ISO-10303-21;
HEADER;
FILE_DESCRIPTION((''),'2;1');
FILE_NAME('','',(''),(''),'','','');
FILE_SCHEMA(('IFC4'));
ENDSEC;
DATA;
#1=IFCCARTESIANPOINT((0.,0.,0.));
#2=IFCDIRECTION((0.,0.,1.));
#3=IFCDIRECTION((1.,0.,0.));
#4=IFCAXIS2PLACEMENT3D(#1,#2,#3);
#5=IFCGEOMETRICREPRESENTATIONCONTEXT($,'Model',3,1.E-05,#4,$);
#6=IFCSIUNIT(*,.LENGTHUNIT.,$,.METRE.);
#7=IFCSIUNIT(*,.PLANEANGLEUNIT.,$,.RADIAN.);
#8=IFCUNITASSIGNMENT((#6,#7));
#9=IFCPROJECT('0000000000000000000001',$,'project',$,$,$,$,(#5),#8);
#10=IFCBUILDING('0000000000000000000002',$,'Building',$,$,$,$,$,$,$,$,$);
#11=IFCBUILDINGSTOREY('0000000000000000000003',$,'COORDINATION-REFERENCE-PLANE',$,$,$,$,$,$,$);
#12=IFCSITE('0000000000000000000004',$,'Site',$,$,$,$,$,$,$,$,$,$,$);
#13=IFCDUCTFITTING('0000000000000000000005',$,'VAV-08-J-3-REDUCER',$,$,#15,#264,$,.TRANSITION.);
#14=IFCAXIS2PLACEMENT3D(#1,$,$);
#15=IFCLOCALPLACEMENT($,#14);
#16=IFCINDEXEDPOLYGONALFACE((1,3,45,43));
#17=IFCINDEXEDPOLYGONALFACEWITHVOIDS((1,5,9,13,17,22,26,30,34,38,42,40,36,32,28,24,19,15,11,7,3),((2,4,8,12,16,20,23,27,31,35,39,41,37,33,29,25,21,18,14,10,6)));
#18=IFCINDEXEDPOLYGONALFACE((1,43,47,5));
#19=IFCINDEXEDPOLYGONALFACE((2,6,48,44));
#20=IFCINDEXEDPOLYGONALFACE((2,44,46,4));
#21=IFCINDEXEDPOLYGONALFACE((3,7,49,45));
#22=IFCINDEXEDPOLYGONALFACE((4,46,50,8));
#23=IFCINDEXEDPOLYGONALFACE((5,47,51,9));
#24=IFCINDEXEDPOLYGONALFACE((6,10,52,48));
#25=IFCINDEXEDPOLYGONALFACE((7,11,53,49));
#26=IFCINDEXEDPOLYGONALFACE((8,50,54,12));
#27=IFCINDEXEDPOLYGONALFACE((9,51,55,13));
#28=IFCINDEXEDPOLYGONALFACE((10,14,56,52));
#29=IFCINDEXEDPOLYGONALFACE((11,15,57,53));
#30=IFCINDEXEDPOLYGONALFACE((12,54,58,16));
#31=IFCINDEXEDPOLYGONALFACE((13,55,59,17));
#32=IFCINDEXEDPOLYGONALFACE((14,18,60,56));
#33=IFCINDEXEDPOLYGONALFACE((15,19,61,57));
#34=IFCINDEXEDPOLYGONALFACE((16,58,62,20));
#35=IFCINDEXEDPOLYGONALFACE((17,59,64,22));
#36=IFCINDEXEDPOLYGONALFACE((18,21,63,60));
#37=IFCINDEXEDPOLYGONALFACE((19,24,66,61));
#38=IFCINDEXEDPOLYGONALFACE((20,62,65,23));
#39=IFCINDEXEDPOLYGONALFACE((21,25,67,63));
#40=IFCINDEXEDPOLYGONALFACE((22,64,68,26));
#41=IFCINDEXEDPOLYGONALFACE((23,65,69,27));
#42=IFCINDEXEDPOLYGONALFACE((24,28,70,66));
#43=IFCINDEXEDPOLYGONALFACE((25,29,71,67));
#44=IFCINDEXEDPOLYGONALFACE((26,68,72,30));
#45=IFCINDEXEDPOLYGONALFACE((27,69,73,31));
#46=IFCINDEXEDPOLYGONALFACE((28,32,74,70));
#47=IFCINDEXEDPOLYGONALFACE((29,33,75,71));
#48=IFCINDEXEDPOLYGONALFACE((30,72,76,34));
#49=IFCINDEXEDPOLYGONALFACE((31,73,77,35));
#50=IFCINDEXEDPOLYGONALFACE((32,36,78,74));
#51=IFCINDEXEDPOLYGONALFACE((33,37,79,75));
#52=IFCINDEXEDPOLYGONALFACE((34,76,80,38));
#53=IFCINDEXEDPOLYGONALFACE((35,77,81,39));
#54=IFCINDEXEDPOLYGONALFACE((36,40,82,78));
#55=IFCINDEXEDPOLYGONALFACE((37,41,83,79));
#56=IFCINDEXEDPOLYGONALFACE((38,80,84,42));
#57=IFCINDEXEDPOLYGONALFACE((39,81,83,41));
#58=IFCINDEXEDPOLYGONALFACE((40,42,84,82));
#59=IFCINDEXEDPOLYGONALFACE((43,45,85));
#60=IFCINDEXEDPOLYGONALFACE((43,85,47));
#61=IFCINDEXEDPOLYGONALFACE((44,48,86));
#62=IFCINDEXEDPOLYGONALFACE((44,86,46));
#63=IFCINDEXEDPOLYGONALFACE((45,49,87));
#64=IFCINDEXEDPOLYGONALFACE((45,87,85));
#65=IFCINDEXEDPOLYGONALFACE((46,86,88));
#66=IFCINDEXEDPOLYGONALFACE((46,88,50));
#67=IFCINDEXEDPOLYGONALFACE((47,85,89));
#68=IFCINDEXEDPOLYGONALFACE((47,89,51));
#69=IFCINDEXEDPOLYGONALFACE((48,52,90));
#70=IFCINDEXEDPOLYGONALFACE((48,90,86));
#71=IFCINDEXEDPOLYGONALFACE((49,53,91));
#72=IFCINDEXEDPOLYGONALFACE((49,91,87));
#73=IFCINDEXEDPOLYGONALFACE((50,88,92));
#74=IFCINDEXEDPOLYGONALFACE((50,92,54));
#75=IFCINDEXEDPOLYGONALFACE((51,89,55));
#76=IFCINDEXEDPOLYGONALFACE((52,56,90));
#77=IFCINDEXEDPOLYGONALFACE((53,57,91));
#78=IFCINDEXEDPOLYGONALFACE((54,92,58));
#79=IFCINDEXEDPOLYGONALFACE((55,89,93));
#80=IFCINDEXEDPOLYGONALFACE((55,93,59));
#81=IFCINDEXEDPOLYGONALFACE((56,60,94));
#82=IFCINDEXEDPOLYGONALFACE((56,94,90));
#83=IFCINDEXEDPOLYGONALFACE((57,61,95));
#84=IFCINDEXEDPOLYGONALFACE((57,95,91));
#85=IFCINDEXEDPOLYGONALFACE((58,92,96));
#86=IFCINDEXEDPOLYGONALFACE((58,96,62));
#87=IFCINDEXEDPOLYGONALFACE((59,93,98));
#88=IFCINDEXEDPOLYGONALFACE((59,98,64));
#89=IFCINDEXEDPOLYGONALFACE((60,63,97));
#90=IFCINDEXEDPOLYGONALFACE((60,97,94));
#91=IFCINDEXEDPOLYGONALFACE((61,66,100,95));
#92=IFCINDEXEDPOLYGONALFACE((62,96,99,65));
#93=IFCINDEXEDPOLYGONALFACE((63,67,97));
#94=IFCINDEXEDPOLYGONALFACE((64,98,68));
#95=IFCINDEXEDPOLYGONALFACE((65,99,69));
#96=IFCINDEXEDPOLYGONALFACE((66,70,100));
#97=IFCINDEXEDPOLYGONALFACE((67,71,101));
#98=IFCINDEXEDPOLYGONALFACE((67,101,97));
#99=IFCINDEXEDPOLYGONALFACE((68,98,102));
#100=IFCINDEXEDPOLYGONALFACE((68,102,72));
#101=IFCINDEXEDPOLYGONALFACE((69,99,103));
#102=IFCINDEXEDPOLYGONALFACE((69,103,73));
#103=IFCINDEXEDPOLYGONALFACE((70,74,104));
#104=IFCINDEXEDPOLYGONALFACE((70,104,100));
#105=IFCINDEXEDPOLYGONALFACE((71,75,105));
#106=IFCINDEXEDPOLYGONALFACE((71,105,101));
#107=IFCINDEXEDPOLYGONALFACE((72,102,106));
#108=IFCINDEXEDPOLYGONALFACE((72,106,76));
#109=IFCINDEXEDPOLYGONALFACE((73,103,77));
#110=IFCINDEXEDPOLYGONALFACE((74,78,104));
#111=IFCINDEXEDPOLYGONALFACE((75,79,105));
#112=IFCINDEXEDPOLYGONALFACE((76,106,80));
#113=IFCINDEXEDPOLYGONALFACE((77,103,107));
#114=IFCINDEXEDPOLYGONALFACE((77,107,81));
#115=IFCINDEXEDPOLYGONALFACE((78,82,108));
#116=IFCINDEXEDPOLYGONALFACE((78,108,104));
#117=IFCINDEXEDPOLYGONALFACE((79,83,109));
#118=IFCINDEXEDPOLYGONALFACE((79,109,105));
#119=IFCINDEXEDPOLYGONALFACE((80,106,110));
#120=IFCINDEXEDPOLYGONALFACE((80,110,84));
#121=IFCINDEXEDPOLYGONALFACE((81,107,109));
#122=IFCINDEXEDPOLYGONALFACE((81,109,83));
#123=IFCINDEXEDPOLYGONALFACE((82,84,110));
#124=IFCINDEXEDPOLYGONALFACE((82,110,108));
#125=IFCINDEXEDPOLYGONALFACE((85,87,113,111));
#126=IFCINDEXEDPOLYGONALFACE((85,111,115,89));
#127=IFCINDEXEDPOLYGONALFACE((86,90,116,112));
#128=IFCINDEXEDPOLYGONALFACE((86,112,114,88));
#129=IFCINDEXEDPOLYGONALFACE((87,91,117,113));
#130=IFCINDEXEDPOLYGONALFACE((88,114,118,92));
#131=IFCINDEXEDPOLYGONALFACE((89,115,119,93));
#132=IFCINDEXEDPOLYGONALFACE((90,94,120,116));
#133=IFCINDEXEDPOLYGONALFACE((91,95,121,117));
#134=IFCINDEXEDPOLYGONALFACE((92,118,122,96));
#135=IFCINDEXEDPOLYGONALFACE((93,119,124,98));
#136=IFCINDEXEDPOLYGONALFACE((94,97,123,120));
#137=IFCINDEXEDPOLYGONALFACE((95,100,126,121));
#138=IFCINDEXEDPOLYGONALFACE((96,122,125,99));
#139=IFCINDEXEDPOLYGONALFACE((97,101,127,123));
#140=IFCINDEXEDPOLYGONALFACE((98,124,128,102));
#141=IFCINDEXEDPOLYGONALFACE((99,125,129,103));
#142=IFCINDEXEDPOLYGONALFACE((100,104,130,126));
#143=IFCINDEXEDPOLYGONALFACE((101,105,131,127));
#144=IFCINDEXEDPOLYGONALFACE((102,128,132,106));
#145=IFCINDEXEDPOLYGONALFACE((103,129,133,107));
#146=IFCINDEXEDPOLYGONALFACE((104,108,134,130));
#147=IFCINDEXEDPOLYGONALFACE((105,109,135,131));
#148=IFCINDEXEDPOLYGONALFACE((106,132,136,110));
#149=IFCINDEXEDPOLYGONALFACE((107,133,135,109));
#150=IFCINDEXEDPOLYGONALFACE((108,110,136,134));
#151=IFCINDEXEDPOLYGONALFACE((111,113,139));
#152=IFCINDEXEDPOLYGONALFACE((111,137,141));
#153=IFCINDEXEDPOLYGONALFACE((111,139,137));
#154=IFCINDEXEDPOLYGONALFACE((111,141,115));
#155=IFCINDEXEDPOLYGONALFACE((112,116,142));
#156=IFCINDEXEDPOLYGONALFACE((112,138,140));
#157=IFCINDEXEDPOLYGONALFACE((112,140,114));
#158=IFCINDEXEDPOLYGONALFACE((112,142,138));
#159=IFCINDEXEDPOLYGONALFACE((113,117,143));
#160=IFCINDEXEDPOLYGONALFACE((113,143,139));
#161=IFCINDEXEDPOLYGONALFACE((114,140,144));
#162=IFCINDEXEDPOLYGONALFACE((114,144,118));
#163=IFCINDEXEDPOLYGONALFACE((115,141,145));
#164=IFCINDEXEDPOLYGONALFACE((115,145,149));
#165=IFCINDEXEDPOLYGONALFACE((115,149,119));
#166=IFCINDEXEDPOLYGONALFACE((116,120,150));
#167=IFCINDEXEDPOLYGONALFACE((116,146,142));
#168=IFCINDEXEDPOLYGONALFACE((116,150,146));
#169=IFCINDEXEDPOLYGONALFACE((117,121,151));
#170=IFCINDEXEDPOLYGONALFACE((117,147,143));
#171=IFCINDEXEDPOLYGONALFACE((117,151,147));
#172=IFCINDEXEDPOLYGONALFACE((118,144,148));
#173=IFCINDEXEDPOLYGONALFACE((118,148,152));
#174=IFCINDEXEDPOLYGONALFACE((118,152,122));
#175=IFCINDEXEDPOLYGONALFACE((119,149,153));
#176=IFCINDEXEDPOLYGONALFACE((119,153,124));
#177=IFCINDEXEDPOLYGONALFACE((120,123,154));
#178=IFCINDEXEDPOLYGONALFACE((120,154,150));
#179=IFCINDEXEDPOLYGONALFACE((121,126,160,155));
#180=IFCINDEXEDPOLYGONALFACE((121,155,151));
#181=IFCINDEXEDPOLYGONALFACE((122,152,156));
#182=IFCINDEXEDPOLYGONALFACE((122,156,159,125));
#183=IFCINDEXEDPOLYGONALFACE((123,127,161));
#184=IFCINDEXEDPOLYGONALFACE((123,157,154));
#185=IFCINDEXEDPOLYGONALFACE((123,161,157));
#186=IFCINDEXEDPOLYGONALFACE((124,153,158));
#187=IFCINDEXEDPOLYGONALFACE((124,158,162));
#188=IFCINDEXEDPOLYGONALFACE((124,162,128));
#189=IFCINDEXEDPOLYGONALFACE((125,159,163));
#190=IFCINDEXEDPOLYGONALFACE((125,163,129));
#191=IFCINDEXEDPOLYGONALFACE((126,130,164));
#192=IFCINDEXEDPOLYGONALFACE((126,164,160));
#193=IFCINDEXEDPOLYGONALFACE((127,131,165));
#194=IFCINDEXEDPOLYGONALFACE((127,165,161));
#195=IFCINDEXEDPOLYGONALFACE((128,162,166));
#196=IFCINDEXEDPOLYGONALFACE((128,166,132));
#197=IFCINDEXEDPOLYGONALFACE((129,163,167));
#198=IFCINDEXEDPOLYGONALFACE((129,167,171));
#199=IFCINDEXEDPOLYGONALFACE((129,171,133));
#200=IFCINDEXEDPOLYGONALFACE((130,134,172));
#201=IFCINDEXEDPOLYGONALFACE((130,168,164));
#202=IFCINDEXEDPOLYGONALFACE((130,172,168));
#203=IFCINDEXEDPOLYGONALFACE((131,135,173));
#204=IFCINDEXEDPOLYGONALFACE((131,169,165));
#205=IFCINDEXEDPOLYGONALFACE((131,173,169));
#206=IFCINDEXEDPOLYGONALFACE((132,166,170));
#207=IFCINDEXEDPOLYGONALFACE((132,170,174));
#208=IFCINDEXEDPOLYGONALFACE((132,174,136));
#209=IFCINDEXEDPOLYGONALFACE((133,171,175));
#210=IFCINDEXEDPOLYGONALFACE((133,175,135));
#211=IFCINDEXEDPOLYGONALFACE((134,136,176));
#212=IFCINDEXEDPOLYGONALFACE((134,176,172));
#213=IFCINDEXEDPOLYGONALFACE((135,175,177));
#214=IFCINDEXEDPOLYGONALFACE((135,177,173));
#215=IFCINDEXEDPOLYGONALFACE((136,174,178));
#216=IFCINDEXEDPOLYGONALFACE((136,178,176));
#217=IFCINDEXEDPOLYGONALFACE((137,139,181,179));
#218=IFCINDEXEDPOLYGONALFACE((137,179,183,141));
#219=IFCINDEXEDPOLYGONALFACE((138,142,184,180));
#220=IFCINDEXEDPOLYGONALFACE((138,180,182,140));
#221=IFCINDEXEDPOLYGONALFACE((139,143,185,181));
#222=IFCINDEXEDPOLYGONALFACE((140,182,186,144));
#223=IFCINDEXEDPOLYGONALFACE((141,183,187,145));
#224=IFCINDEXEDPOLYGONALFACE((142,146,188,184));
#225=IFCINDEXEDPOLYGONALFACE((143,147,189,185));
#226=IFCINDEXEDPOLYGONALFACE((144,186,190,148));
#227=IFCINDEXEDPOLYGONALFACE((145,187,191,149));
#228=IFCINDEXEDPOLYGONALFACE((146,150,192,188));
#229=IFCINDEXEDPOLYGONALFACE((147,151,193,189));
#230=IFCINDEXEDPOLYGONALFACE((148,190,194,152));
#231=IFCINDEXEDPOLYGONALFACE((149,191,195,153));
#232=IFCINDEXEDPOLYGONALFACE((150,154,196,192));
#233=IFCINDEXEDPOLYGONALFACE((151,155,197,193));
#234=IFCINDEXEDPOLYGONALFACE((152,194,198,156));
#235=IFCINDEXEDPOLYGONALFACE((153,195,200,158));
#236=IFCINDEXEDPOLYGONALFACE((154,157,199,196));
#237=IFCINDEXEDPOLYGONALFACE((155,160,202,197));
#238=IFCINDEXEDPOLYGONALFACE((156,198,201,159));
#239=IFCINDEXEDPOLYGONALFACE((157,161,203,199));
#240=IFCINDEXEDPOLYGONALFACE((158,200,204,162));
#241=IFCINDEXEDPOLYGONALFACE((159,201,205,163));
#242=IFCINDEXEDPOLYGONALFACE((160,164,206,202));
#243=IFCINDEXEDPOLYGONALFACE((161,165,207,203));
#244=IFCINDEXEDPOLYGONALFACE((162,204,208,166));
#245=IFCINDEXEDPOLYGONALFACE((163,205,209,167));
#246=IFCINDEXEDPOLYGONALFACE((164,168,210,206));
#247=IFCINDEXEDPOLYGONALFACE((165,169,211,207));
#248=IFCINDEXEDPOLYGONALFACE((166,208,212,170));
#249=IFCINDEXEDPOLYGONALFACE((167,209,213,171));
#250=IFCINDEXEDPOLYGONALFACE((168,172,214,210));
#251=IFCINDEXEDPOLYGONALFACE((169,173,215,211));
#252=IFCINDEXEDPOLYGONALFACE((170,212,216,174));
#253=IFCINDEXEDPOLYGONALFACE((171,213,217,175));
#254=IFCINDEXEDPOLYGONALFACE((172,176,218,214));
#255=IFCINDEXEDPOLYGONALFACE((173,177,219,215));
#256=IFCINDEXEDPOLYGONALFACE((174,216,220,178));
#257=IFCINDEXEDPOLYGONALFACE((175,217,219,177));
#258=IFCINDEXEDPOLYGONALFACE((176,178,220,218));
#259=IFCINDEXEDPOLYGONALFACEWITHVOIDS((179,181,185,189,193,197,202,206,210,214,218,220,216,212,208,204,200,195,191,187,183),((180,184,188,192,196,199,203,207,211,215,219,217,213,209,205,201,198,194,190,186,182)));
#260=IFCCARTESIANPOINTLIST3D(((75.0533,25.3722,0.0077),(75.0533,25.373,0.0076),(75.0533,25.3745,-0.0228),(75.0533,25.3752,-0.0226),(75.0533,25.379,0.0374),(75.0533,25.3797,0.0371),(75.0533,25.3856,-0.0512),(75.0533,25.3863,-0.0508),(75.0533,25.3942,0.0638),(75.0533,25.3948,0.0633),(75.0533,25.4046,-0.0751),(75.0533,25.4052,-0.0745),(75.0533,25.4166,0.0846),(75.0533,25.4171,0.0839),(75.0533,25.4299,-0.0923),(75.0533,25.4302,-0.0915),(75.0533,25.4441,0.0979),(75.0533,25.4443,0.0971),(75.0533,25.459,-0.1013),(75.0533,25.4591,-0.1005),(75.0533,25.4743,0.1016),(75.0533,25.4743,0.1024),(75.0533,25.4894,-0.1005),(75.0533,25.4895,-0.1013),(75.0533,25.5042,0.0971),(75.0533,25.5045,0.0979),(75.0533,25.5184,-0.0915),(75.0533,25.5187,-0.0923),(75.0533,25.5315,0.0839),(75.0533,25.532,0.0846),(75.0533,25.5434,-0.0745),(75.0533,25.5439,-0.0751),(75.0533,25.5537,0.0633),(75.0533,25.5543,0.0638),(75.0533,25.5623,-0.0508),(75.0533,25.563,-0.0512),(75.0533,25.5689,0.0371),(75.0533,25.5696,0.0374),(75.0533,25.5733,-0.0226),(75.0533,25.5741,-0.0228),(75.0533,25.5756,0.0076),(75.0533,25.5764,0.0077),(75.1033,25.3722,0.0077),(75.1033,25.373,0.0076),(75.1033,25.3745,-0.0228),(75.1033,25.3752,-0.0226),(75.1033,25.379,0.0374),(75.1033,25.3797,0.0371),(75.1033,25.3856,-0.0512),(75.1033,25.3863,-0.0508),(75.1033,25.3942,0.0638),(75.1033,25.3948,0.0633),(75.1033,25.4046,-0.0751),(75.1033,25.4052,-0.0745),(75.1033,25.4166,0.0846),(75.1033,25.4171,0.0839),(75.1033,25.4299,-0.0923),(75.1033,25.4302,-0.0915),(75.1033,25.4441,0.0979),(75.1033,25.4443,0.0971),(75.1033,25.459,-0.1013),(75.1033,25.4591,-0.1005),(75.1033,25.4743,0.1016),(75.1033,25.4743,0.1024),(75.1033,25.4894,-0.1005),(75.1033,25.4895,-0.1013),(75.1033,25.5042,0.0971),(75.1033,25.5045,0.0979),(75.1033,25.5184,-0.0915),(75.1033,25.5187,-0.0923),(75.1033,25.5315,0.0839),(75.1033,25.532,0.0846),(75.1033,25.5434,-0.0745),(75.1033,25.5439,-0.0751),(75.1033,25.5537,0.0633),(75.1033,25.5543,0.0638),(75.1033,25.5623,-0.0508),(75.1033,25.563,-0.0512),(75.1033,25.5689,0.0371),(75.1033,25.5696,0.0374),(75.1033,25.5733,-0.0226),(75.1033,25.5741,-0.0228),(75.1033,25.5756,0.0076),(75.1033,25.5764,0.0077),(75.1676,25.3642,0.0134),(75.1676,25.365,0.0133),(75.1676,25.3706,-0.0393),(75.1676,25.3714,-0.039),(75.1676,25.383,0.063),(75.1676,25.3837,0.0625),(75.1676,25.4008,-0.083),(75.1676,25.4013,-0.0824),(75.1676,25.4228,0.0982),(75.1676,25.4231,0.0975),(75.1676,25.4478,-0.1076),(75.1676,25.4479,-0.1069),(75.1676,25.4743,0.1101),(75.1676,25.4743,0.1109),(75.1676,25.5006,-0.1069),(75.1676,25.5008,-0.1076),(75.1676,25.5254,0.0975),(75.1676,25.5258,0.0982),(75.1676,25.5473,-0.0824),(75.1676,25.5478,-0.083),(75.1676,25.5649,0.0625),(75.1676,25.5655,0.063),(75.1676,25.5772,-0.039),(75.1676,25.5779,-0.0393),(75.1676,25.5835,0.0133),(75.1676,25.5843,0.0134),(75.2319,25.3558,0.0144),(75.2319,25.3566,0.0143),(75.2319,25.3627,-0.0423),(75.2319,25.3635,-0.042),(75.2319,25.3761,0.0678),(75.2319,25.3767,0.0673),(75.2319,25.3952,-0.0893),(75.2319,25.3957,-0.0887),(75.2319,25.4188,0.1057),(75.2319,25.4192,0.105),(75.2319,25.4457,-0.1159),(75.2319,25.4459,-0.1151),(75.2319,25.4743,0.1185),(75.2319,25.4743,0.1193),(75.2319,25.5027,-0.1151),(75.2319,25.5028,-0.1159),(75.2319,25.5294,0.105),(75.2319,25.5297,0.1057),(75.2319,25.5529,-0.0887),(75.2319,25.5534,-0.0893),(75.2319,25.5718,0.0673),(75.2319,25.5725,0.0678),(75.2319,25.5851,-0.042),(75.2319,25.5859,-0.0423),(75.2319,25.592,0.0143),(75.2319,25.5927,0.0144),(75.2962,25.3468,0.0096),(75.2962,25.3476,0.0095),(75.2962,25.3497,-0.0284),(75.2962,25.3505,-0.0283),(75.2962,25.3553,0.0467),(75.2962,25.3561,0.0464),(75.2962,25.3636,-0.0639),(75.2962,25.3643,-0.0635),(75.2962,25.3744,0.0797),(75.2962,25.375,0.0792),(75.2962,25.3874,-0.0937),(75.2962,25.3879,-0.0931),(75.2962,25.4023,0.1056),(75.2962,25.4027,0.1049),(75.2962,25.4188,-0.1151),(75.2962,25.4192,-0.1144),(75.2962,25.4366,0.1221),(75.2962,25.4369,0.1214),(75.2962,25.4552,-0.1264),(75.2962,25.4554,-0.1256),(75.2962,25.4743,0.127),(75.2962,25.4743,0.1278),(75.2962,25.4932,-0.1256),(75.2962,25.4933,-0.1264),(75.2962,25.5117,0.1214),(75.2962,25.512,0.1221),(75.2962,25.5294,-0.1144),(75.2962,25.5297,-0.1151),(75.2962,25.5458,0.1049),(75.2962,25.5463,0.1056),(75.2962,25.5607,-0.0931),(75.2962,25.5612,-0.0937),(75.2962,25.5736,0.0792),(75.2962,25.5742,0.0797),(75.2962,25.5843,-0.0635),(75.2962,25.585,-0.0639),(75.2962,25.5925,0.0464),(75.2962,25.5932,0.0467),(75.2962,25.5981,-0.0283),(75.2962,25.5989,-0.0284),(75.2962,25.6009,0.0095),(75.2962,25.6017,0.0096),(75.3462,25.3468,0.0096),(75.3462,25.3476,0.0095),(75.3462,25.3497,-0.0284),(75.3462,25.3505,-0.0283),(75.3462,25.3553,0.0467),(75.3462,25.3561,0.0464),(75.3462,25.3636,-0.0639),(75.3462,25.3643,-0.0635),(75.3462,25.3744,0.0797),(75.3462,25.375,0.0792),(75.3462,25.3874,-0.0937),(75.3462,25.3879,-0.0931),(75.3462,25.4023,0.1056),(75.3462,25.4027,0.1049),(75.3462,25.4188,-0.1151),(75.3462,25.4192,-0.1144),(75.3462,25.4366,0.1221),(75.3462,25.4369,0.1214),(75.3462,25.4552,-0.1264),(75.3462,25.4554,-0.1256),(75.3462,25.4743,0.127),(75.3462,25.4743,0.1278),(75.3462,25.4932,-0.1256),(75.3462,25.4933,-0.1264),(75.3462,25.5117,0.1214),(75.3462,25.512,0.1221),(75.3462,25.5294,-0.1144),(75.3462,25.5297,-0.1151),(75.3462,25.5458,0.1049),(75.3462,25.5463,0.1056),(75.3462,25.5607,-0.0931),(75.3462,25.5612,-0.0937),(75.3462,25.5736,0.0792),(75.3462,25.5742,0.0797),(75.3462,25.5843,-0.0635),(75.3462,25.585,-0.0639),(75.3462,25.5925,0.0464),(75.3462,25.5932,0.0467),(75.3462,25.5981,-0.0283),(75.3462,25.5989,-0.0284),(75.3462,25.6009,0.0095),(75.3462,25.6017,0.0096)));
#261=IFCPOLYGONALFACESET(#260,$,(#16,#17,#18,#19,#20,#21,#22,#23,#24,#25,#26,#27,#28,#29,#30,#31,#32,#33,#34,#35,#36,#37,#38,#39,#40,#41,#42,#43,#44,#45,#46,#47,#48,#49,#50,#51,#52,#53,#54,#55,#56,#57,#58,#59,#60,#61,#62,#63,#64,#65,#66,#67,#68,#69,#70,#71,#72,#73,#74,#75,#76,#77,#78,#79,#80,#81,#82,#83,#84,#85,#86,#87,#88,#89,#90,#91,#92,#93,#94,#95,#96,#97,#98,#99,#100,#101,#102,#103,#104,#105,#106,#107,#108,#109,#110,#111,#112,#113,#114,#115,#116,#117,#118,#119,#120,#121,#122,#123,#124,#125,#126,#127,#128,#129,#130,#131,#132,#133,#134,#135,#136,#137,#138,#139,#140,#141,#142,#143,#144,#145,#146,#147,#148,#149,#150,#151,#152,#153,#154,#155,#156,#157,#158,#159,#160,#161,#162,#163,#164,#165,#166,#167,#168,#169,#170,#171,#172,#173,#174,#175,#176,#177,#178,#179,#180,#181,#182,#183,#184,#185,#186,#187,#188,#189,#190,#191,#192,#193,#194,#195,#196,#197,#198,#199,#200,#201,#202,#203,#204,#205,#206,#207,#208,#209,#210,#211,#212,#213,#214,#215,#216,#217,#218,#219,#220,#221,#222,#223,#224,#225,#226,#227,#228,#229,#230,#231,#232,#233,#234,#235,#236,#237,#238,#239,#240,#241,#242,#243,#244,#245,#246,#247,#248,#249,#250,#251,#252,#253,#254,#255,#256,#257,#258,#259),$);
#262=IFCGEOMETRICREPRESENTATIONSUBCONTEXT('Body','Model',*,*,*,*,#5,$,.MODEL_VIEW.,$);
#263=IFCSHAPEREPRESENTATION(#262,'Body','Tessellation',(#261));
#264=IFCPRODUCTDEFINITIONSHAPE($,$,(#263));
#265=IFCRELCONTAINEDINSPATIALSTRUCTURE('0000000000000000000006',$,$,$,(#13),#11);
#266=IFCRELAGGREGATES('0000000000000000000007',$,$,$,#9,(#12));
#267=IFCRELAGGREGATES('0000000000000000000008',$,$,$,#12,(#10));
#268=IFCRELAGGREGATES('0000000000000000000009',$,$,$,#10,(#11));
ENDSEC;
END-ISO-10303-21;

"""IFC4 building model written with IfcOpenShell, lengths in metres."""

from ifc_helpers import new_model, entity, si_unit, frame, origin_with_axes, place, context, subcontext, project, spatial, element, save


model = new_model("IFC4")

# Units and contexts
model_context = context("Model", 3, precision=1e-05, world=origin_with_axes())
body_context_1 = subcontext(model_context, "Body", "Model", "MODEL_VIEW")
ifc_project = project(units=[si_unit("LENGTHUNIT", "METRE"), si_unit("PLANEANGLEUNIT", "RADIAN")], contexts=[model_context])

# Site, building, storey
site = spatial("IfcSite", under=ifc_project, Name="Site")
building = spatial("IfcBuilding", under=site, Name="Building")
storey = spatial("IfcBuildingStorey", under=building, Name="COORDINATION-REFERENCE-PLANE")

# Duct fitting
for number, where, z_axis, x_axis, name in (
    (1, (75.3462, 25.4743, 0.0), (0.0, -1.0, 0.0), (0.0, 0.0, 1.0), "VAV-08-J-3-REDUCER"),
):
    element("IfcDuctFitting", number, at=place(None, frame(where, z_axis=z_axis, x_axis=x_axis)), inside=storey, Name=name, PredefinedType="TRANSITION", context=body_context_1, shape_type="SweptSolid", body=[
        entity("IfcRevolvedAreaSolid", entity("IfcArbitraryClosedProfileDef", "AREA", None, entity("IfcPolyline", [entity("IfcCartesianPoint", [0.1278, 0.0]), entity("IfcCartesianPoint", [0.1278, 0.05]), entity("IfcCartesianPoint", [0.1024, 0.2429]), entity("IfcCartesianPoint", [0.1024, 0.2929]), entity("IfcCartesianPoint", [0.1016, 0.2929]), entity("IfcCartesianPoint", [0.1016, 0.2429]), entity("IfcCartesianPoint", [0.127, 0.05]), entity("IfcCartesianPoint", [0.127, 0.0]), entity("IfcCartesianPoint", [0.1278, 0.0])])), entity("IfcAxis2Placement3D", entity("IfcCartesianPoint", [0.0, 0.0, 0.0])), entity("IfcAxis1Placement", entity("IfcCartesianPoint", [0.0, 0.0, 0.0]), entity("IfcDirection", [0.0, 1.0, 0.0])), 6.283185),
    ])

save(model, "model.ifc")
